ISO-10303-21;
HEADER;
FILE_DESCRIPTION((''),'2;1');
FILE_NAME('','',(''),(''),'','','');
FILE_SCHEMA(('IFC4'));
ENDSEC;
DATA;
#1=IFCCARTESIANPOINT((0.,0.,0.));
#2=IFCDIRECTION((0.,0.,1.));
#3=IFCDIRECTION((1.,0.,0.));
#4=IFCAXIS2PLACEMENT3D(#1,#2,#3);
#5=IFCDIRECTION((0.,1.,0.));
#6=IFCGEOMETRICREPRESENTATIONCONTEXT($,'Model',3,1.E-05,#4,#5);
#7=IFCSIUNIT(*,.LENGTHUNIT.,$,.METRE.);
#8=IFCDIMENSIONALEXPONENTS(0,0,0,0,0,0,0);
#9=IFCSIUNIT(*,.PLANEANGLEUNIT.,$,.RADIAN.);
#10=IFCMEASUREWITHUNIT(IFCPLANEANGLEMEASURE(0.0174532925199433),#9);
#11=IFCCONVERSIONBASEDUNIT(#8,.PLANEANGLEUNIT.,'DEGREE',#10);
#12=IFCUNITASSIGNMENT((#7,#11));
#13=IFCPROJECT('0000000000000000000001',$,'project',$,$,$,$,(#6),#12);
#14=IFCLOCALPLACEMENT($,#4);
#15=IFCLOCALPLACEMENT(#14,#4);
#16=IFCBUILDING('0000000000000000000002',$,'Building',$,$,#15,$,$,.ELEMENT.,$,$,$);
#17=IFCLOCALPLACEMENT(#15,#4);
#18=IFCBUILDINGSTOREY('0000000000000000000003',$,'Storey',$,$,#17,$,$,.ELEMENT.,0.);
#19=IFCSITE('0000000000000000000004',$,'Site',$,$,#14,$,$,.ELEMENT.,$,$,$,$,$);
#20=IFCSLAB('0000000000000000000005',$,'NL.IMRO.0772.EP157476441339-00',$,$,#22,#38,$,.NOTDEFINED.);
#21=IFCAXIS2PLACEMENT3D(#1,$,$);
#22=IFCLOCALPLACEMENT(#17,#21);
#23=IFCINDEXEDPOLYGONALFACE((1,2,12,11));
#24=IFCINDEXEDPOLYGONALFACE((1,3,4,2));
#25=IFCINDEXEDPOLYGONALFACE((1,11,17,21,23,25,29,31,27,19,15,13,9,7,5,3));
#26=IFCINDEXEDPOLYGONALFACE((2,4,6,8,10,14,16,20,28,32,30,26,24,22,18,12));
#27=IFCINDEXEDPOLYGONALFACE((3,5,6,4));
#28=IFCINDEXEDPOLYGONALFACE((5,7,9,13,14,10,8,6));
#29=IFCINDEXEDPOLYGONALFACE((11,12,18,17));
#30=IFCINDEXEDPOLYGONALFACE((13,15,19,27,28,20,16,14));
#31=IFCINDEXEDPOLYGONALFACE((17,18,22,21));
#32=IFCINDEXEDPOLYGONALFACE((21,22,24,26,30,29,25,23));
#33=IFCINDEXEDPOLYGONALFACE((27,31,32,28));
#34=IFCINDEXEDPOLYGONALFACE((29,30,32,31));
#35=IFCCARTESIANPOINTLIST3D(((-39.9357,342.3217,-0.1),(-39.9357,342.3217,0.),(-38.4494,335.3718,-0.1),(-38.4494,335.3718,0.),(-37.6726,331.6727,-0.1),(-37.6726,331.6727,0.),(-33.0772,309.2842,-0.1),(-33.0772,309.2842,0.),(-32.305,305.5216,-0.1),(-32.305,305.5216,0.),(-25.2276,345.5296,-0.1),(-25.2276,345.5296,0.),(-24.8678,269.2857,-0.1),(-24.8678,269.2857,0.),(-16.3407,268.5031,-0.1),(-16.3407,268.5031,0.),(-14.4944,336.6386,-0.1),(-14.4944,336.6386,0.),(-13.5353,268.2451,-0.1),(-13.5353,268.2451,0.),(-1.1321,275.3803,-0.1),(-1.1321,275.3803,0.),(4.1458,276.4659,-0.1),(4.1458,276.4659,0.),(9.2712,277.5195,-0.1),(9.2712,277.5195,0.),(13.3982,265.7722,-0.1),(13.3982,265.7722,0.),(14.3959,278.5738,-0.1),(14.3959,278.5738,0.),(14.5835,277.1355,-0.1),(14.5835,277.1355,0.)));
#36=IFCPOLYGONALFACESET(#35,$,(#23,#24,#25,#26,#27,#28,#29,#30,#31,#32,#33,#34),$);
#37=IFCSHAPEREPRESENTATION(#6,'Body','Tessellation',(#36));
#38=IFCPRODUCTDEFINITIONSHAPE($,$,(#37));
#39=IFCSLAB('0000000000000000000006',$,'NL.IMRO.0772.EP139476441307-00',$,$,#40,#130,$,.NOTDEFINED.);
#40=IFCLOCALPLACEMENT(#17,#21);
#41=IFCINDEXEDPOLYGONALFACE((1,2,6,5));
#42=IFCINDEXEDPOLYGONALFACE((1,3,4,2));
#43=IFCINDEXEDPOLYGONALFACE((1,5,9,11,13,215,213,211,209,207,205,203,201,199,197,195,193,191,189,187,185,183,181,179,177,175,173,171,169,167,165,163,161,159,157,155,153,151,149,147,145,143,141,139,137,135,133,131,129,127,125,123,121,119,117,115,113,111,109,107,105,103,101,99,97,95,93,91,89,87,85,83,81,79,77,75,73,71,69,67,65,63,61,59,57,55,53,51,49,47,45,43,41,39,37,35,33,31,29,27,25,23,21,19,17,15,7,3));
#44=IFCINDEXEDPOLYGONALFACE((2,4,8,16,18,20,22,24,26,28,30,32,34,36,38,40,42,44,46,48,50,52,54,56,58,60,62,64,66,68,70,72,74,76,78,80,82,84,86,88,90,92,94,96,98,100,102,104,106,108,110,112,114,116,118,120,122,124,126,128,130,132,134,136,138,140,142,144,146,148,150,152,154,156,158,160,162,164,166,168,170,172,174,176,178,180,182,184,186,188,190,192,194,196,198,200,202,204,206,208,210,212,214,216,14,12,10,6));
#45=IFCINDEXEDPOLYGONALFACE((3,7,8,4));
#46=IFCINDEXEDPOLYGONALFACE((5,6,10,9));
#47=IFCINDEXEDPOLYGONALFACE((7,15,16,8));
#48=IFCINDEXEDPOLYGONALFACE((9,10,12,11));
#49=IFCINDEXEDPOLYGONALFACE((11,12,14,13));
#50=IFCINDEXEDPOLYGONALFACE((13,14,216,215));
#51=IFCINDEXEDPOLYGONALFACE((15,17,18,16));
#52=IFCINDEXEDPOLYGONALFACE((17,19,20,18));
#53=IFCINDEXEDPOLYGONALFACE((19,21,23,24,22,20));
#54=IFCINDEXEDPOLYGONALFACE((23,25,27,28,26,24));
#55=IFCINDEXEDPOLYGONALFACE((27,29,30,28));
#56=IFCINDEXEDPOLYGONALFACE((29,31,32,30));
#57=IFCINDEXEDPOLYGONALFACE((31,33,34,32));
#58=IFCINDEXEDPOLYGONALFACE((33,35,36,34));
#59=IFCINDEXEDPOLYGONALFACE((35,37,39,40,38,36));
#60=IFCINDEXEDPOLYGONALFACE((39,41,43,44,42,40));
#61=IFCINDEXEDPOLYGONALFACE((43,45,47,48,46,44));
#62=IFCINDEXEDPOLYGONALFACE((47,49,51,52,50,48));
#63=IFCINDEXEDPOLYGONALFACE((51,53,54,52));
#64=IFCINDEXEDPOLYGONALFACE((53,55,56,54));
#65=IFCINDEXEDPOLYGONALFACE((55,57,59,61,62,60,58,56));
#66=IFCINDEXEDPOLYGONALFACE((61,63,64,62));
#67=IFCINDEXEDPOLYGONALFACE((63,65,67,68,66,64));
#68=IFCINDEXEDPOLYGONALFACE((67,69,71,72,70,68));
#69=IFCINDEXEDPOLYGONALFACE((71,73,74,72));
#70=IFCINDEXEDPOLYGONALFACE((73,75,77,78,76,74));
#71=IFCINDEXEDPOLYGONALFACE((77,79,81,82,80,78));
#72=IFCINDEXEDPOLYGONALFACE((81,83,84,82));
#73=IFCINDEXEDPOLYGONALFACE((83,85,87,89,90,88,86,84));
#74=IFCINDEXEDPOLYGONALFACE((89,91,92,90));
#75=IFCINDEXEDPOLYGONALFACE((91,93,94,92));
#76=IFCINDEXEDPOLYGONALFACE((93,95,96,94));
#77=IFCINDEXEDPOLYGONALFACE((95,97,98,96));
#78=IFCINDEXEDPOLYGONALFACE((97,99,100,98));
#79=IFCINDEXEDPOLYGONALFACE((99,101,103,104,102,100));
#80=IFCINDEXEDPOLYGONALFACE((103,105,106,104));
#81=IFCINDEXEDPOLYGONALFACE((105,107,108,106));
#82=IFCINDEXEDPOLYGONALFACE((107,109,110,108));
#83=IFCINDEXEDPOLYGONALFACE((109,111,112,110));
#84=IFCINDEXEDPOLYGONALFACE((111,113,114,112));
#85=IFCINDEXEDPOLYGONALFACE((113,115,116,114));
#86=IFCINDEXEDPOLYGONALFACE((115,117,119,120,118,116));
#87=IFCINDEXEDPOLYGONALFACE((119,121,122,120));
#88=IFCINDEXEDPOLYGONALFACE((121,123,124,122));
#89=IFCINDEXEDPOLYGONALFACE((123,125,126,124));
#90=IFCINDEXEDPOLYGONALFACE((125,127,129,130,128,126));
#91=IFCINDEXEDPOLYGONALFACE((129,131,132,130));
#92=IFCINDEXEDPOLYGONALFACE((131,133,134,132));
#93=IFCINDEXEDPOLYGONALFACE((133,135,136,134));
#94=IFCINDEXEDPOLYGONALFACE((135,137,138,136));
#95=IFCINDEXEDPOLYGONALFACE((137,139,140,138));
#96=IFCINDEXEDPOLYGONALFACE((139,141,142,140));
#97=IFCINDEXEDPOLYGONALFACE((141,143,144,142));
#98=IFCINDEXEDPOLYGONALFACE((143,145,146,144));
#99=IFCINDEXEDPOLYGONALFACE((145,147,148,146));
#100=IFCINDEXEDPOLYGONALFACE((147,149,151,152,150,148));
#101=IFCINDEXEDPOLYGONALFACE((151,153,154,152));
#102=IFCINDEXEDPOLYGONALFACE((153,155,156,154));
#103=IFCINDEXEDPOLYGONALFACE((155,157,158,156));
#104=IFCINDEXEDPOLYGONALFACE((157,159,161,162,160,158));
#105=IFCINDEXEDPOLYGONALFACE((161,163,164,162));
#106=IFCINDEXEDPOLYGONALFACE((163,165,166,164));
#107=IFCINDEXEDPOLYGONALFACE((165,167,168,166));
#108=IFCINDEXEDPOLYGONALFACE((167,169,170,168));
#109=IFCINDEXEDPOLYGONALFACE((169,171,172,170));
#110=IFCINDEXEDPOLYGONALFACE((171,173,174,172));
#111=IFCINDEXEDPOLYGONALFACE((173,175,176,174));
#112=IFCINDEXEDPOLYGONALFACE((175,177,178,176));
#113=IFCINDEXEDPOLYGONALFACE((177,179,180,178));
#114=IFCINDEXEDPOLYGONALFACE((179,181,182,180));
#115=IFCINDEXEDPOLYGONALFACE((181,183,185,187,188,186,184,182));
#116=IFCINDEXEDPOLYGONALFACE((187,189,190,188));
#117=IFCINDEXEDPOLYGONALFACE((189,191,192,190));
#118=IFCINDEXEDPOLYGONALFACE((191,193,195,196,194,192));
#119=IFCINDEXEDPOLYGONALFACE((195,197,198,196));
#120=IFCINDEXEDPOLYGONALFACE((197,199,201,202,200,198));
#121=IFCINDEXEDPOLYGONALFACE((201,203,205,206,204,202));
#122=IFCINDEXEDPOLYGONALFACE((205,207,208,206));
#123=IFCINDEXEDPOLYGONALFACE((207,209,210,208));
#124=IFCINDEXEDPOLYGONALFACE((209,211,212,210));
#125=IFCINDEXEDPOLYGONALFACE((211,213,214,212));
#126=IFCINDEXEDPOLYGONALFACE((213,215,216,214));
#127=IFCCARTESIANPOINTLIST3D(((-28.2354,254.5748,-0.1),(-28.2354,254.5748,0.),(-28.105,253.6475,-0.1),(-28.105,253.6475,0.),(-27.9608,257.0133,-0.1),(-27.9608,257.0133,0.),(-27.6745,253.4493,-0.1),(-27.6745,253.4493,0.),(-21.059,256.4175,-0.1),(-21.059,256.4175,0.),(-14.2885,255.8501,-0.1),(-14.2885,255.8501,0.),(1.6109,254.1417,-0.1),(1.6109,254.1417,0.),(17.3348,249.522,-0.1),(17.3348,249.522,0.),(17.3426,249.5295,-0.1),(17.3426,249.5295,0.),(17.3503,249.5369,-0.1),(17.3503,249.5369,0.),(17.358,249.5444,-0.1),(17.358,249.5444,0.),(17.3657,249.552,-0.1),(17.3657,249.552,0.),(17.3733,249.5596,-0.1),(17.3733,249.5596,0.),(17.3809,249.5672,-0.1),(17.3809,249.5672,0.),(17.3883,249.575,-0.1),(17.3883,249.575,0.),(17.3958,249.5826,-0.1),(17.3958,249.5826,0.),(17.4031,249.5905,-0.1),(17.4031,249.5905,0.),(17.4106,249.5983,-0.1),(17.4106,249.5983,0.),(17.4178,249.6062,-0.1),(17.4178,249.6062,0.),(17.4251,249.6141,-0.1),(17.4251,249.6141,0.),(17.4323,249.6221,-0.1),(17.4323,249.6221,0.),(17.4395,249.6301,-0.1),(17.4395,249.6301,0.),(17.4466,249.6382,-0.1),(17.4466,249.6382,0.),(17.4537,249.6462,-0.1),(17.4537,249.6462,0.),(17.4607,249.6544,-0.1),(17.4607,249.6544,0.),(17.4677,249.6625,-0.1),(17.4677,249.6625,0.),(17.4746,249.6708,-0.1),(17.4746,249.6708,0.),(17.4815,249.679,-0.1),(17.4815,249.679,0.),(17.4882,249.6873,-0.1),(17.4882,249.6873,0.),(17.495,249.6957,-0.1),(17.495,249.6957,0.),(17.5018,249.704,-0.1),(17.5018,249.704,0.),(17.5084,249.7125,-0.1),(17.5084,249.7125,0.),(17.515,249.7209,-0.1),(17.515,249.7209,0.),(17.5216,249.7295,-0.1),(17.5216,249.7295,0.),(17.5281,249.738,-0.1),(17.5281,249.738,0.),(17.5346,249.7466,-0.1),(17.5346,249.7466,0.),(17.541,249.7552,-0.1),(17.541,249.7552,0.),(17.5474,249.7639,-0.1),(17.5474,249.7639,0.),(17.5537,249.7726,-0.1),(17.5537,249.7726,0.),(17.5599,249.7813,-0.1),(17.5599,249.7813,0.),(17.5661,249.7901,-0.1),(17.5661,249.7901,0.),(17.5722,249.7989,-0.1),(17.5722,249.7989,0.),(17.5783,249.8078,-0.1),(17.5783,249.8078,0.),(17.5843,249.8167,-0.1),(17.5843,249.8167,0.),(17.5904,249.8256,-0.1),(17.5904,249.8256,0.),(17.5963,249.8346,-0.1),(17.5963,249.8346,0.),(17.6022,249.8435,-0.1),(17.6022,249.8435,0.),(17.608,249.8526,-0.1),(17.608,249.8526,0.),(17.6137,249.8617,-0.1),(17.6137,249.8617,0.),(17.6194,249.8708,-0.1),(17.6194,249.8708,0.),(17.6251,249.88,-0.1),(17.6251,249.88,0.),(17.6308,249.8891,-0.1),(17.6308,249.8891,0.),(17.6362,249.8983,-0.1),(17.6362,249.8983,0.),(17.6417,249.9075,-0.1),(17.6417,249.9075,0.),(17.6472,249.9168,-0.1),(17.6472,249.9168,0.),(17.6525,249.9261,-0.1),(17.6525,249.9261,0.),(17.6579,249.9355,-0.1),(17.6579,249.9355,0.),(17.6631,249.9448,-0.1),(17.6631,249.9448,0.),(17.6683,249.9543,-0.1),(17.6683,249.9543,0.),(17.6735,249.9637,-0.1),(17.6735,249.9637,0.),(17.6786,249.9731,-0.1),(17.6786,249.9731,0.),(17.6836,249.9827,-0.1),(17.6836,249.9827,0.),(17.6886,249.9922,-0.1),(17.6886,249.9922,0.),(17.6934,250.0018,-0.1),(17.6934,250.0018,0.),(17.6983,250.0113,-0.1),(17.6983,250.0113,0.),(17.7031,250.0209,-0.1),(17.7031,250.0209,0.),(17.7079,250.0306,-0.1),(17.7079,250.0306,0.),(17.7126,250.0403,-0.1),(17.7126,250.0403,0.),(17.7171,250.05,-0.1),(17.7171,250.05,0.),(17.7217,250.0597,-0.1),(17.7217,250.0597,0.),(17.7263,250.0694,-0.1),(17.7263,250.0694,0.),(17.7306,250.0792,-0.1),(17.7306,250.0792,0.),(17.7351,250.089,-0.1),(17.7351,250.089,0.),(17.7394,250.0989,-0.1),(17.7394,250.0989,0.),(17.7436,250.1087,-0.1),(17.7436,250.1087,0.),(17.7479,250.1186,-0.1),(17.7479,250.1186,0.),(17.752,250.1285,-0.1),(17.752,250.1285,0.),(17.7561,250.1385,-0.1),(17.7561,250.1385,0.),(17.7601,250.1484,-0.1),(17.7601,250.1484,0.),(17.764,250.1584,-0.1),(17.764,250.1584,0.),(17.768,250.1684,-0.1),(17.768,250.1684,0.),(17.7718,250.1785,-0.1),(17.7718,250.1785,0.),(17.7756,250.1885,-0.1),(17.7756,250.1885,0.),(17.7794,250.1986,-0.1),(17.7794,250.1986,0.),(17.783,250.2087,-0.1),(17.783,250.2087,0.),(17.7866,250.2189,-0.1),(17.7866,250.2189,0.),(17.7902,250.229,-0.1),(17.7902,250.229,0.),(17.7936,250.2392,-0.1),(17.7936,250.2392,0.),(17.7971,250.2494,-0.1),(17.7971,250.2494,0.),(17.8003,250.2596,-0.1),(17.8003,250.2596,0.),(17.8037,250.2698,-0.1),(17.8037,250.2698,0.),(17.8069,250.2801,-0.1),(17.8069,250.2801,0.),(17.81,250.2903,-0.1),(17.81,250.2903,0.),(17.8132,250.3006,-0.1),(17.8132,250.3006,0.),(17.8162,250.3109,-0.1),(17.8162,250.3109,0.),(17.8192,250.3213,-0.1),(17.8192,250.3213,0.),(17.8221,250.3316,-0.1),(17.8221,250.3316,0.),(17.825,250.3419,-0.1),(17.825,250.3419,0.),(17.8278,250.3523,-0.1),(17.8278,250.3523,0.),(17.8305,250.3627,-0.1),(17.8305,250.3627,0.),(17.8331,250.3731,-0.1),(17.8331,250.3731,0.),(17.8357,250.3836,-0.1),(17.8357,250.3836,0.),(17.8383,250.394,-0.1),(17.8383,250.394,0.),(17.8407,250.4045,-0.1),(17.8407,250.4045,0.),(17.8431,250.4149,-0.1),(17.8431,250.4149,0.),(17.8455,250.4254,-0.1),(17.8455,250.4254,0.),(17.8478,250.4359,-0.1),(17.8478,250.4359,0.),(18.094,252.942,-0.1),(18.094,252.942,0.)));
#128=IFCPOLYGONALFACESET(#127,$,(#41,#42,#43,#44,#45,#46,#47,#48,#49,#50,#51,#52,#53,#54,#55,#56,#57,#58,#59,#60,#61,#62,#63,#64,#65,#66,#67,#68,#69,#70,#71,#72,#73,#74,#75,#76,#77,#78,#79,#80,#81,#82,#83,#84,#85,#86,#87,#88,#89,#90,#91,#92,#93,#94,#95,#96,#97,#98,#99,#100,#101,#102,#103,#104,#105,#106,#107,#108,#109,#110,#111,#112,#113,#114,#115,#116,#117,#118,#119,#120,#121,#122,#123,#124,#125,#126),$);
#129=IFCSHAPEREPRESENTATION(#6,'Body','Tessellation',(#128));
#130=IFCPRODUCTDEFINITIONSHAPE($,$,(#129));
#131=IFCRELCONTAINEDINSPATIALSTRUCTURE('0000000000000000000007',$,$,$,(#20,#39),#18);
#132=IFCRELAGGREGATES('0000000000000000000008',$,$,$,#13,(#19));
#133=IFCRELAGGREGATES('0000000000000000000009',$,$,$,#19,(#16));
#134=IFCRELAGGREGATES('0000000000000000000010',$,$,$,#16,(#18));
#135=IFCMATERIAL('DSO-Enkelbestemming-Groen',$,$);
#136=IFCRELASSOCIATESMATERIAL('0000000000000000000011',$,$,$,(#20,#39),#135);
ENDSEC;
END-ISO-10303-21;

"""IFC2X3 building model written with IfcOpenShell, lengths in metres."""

from ifc_helpers import new_model, entity, si_unit, converted_unit, direction, frame, origin_with_axes, place, context, project, spatial, polyline, outline, extrude, material, element, save


model = new_model("IFC2X3")

# Units and contexts
model_context = context("Model", 3, precision=1e-05, world=origin_with_axes(), true_north=direction((0.0, 1.0, 0.0)))
ifc_project = project(units=[si_unit("LENGTHUNIT", "METRE"), converted_unit("PLANEANGLEUNIT", "DEGREE", entity("IfcPlaneAngleMeasure", 0.0174532925199433), si_unit("PLANEANGLEUNIT", "RADIAN"), dimensions=[0, 0, 0, 0, 0, 0, 0])], contexts=[model_context])

# Site, building, storey
site_placement = place(None, origin_with_axes())
site = spatial("IfcSite", under=ifc_project, at=site_placement, Name="Site", CompositionType="ELEMENT")
building_placement = place(site_placement, origin_with_axes())
building = spatial("IfcBuilding", under=site, at=building_placement, Name="Building", CompositionType="ELEMENT")
storey_placement = place(building_placement, origin_with_axes())
storey = spatial("IfcBuildingStorey", under=building, at=storey_placement, Name="Storey", CompositionType="ELEMENT", Elevation=0.0)

# Slabs
ifc_material_1 = material(Name="DSO-Enkelbestemming-Groen")
slab_1_placement = place(storey_placement, frame((0.0, 0.0, -0.1), z_axis=(0.0, 0.0, 1.0), x_axis=(1.0, 0.0, 0.0)))
element("IfcSlab", 1, at=slab_1_placement, inside=storey, material=ifc_material_1, Name="NL.IMRO.0772.EP157476441339-00", PredefinedType="NOTDEFINED", context=model_context, shape_type="SweptSolid", body=[
    extrude(outline(polyline([(-1.1321, 275.3803), (4.1458, 276.4659), (9.2712, 277.5195), (14.3959, 278.5738), (14.5835, 277.1355), (13.3982, 265.7722), (-13.5353, 268.2451), (-16.3407, 268.5031), (-24.8678, 269.2857), (-32.305, 305.5216), (-33.0772, 309.2842), (-37.6726, 331.6727), (-38.4494, 335.3718), (-39.9357, 342.3217), (-25.2276, 345.5296), (-14.4944, 336.6386), (-1.1321, 275.3803)])), origin_with_axes(), (0.0, 0.0, 1.0), 0.1),
])
slab_2_placement = place(storey_placement, frame((0.0, 0.0, -0.1), z_axis=(0.0, 0.0, 1.0), x_axis=(1.0, 0.0, 0.0)))
element("IfcSlab", 2, at=slab_2_placement, inside=storey, material=ifc_material_1, Name="NL.IMRO.0772.EP139476441307-00", PredefinedType="NOTDEFINED", context=model_context, shape_type="SweptSolid", body=[
    extrude(outline(polyline([(-27.6745, 253.4493), (-28.105, 253.6475), (-28.2354, 254.5748), (-27.9608, 257.0133), (-21.059, 256.4175), (-14.2885, 255.8501), (1.6109, 254.1417), (18.094, 252.942), (17.8478, 250.4359), (17.8455, 250.4254), (17.8431, 250.4149), (17.8407, 250.4045), (17.8383, 250.394), (17.8357, 250.3836), (17.8331, 250.3731), (17.8305, 250.3627), (17.8278, 250.3523), (17.825, 250.3419), (17.8221, 250.3316), (17.8192, 250.3213), (17.8162, 250.3109), (17.8132, 250.3006), (17.81, 250.2903), (17.8069, 250.2801), (17.8037, 250.2698), (17.8003, 250.2596), (17.7971, 250.2494), (17.7936, 250.2392), (17.7902, 250.229), (17.7866, 250.2189), (17.783, 250.2087), (17.7794, 250.1986), (17.7756, 250.1885), (17.7718, 250.1785), (17.768, 250.1684), (17.764, 250.1584), (17.7601, 250.1484), (17.7561, 250.1385), (17.752, 250.1285), (17.7479, 250.1186), (17.7436, 250.1087), (17.7394, 250.0989), (17.7351, 250.089), (17.7306, 250.0792), (17.7263, 250.0694), (17.7217, 250.0597), (17.7171, 250.05), (17.7126, 250.0403), (17.7079, 250.0306), (17.7031, 250.0209), (17.6983, 250.0113), (17.6934, 250.0018), (17.6886, 249.9922), (17.6836, 249.9827), (17.6786, 249.9731), (17.6735, 249.9637), (17.6683, 249.9543), (17.6631, 249.9448), (17.6579, 249.9355), (17.6525, 249.9261), (17.6472, 249.9168), (17.6417, 249.9075), (17.6362, 249.8983), (17.6308, 249.8891), (17.6251, 249.88), (17.6194, 249.8708), (17.6137, 249.8617), (17.608, 249.8526), (17.6022, 249.8435), (17.5963, 249.8346), (17.5904, 249.8256), (17.5843, 249.8167), (17.5783, 249.8078), (17.5722, 249.7989), (17.5661, 249.7901), (17.5599, 249.7813), (17.5537, 249.7726), (17.5474, 249.7639), (17.541, 249.7552), (17.5346, 249.7466), (17.5281, 249.738), (17.5216, 249.7295), (17.515, 249.7209), (17.5084, 249.7125), (17.5018, 249.704), (17.495, 249.6957), (17.4882, 249.6873), (17.4815, 249.679), (17.4746, 249.6708), (17.4677, 249.6625), (17.4607, 249.6544), (17.4537, 249.6462), (17.4466, 249.6382), (17.4395, 249.6301), (17.4323, 249.6221), (17.4251, 249.6141), (17.4178, 249.6062), (17.4106, 249.5983), (17.4031, 249.5905), (17.3958, 249.5826), (17.3883, 249.575), (17.3809, 249.5672), (17.3733, 249.5596), (17.3657, 249.552), (17.358, 249.5444), (17.3503, 249.5369), (17.3426, 249.5295), (17.3348, 249.522), (-27.6745, 253.4493)])), origin_with_axes(), (0.0, 0.0, 1.0), 0.1),
])

save(model, "model.ifc")
